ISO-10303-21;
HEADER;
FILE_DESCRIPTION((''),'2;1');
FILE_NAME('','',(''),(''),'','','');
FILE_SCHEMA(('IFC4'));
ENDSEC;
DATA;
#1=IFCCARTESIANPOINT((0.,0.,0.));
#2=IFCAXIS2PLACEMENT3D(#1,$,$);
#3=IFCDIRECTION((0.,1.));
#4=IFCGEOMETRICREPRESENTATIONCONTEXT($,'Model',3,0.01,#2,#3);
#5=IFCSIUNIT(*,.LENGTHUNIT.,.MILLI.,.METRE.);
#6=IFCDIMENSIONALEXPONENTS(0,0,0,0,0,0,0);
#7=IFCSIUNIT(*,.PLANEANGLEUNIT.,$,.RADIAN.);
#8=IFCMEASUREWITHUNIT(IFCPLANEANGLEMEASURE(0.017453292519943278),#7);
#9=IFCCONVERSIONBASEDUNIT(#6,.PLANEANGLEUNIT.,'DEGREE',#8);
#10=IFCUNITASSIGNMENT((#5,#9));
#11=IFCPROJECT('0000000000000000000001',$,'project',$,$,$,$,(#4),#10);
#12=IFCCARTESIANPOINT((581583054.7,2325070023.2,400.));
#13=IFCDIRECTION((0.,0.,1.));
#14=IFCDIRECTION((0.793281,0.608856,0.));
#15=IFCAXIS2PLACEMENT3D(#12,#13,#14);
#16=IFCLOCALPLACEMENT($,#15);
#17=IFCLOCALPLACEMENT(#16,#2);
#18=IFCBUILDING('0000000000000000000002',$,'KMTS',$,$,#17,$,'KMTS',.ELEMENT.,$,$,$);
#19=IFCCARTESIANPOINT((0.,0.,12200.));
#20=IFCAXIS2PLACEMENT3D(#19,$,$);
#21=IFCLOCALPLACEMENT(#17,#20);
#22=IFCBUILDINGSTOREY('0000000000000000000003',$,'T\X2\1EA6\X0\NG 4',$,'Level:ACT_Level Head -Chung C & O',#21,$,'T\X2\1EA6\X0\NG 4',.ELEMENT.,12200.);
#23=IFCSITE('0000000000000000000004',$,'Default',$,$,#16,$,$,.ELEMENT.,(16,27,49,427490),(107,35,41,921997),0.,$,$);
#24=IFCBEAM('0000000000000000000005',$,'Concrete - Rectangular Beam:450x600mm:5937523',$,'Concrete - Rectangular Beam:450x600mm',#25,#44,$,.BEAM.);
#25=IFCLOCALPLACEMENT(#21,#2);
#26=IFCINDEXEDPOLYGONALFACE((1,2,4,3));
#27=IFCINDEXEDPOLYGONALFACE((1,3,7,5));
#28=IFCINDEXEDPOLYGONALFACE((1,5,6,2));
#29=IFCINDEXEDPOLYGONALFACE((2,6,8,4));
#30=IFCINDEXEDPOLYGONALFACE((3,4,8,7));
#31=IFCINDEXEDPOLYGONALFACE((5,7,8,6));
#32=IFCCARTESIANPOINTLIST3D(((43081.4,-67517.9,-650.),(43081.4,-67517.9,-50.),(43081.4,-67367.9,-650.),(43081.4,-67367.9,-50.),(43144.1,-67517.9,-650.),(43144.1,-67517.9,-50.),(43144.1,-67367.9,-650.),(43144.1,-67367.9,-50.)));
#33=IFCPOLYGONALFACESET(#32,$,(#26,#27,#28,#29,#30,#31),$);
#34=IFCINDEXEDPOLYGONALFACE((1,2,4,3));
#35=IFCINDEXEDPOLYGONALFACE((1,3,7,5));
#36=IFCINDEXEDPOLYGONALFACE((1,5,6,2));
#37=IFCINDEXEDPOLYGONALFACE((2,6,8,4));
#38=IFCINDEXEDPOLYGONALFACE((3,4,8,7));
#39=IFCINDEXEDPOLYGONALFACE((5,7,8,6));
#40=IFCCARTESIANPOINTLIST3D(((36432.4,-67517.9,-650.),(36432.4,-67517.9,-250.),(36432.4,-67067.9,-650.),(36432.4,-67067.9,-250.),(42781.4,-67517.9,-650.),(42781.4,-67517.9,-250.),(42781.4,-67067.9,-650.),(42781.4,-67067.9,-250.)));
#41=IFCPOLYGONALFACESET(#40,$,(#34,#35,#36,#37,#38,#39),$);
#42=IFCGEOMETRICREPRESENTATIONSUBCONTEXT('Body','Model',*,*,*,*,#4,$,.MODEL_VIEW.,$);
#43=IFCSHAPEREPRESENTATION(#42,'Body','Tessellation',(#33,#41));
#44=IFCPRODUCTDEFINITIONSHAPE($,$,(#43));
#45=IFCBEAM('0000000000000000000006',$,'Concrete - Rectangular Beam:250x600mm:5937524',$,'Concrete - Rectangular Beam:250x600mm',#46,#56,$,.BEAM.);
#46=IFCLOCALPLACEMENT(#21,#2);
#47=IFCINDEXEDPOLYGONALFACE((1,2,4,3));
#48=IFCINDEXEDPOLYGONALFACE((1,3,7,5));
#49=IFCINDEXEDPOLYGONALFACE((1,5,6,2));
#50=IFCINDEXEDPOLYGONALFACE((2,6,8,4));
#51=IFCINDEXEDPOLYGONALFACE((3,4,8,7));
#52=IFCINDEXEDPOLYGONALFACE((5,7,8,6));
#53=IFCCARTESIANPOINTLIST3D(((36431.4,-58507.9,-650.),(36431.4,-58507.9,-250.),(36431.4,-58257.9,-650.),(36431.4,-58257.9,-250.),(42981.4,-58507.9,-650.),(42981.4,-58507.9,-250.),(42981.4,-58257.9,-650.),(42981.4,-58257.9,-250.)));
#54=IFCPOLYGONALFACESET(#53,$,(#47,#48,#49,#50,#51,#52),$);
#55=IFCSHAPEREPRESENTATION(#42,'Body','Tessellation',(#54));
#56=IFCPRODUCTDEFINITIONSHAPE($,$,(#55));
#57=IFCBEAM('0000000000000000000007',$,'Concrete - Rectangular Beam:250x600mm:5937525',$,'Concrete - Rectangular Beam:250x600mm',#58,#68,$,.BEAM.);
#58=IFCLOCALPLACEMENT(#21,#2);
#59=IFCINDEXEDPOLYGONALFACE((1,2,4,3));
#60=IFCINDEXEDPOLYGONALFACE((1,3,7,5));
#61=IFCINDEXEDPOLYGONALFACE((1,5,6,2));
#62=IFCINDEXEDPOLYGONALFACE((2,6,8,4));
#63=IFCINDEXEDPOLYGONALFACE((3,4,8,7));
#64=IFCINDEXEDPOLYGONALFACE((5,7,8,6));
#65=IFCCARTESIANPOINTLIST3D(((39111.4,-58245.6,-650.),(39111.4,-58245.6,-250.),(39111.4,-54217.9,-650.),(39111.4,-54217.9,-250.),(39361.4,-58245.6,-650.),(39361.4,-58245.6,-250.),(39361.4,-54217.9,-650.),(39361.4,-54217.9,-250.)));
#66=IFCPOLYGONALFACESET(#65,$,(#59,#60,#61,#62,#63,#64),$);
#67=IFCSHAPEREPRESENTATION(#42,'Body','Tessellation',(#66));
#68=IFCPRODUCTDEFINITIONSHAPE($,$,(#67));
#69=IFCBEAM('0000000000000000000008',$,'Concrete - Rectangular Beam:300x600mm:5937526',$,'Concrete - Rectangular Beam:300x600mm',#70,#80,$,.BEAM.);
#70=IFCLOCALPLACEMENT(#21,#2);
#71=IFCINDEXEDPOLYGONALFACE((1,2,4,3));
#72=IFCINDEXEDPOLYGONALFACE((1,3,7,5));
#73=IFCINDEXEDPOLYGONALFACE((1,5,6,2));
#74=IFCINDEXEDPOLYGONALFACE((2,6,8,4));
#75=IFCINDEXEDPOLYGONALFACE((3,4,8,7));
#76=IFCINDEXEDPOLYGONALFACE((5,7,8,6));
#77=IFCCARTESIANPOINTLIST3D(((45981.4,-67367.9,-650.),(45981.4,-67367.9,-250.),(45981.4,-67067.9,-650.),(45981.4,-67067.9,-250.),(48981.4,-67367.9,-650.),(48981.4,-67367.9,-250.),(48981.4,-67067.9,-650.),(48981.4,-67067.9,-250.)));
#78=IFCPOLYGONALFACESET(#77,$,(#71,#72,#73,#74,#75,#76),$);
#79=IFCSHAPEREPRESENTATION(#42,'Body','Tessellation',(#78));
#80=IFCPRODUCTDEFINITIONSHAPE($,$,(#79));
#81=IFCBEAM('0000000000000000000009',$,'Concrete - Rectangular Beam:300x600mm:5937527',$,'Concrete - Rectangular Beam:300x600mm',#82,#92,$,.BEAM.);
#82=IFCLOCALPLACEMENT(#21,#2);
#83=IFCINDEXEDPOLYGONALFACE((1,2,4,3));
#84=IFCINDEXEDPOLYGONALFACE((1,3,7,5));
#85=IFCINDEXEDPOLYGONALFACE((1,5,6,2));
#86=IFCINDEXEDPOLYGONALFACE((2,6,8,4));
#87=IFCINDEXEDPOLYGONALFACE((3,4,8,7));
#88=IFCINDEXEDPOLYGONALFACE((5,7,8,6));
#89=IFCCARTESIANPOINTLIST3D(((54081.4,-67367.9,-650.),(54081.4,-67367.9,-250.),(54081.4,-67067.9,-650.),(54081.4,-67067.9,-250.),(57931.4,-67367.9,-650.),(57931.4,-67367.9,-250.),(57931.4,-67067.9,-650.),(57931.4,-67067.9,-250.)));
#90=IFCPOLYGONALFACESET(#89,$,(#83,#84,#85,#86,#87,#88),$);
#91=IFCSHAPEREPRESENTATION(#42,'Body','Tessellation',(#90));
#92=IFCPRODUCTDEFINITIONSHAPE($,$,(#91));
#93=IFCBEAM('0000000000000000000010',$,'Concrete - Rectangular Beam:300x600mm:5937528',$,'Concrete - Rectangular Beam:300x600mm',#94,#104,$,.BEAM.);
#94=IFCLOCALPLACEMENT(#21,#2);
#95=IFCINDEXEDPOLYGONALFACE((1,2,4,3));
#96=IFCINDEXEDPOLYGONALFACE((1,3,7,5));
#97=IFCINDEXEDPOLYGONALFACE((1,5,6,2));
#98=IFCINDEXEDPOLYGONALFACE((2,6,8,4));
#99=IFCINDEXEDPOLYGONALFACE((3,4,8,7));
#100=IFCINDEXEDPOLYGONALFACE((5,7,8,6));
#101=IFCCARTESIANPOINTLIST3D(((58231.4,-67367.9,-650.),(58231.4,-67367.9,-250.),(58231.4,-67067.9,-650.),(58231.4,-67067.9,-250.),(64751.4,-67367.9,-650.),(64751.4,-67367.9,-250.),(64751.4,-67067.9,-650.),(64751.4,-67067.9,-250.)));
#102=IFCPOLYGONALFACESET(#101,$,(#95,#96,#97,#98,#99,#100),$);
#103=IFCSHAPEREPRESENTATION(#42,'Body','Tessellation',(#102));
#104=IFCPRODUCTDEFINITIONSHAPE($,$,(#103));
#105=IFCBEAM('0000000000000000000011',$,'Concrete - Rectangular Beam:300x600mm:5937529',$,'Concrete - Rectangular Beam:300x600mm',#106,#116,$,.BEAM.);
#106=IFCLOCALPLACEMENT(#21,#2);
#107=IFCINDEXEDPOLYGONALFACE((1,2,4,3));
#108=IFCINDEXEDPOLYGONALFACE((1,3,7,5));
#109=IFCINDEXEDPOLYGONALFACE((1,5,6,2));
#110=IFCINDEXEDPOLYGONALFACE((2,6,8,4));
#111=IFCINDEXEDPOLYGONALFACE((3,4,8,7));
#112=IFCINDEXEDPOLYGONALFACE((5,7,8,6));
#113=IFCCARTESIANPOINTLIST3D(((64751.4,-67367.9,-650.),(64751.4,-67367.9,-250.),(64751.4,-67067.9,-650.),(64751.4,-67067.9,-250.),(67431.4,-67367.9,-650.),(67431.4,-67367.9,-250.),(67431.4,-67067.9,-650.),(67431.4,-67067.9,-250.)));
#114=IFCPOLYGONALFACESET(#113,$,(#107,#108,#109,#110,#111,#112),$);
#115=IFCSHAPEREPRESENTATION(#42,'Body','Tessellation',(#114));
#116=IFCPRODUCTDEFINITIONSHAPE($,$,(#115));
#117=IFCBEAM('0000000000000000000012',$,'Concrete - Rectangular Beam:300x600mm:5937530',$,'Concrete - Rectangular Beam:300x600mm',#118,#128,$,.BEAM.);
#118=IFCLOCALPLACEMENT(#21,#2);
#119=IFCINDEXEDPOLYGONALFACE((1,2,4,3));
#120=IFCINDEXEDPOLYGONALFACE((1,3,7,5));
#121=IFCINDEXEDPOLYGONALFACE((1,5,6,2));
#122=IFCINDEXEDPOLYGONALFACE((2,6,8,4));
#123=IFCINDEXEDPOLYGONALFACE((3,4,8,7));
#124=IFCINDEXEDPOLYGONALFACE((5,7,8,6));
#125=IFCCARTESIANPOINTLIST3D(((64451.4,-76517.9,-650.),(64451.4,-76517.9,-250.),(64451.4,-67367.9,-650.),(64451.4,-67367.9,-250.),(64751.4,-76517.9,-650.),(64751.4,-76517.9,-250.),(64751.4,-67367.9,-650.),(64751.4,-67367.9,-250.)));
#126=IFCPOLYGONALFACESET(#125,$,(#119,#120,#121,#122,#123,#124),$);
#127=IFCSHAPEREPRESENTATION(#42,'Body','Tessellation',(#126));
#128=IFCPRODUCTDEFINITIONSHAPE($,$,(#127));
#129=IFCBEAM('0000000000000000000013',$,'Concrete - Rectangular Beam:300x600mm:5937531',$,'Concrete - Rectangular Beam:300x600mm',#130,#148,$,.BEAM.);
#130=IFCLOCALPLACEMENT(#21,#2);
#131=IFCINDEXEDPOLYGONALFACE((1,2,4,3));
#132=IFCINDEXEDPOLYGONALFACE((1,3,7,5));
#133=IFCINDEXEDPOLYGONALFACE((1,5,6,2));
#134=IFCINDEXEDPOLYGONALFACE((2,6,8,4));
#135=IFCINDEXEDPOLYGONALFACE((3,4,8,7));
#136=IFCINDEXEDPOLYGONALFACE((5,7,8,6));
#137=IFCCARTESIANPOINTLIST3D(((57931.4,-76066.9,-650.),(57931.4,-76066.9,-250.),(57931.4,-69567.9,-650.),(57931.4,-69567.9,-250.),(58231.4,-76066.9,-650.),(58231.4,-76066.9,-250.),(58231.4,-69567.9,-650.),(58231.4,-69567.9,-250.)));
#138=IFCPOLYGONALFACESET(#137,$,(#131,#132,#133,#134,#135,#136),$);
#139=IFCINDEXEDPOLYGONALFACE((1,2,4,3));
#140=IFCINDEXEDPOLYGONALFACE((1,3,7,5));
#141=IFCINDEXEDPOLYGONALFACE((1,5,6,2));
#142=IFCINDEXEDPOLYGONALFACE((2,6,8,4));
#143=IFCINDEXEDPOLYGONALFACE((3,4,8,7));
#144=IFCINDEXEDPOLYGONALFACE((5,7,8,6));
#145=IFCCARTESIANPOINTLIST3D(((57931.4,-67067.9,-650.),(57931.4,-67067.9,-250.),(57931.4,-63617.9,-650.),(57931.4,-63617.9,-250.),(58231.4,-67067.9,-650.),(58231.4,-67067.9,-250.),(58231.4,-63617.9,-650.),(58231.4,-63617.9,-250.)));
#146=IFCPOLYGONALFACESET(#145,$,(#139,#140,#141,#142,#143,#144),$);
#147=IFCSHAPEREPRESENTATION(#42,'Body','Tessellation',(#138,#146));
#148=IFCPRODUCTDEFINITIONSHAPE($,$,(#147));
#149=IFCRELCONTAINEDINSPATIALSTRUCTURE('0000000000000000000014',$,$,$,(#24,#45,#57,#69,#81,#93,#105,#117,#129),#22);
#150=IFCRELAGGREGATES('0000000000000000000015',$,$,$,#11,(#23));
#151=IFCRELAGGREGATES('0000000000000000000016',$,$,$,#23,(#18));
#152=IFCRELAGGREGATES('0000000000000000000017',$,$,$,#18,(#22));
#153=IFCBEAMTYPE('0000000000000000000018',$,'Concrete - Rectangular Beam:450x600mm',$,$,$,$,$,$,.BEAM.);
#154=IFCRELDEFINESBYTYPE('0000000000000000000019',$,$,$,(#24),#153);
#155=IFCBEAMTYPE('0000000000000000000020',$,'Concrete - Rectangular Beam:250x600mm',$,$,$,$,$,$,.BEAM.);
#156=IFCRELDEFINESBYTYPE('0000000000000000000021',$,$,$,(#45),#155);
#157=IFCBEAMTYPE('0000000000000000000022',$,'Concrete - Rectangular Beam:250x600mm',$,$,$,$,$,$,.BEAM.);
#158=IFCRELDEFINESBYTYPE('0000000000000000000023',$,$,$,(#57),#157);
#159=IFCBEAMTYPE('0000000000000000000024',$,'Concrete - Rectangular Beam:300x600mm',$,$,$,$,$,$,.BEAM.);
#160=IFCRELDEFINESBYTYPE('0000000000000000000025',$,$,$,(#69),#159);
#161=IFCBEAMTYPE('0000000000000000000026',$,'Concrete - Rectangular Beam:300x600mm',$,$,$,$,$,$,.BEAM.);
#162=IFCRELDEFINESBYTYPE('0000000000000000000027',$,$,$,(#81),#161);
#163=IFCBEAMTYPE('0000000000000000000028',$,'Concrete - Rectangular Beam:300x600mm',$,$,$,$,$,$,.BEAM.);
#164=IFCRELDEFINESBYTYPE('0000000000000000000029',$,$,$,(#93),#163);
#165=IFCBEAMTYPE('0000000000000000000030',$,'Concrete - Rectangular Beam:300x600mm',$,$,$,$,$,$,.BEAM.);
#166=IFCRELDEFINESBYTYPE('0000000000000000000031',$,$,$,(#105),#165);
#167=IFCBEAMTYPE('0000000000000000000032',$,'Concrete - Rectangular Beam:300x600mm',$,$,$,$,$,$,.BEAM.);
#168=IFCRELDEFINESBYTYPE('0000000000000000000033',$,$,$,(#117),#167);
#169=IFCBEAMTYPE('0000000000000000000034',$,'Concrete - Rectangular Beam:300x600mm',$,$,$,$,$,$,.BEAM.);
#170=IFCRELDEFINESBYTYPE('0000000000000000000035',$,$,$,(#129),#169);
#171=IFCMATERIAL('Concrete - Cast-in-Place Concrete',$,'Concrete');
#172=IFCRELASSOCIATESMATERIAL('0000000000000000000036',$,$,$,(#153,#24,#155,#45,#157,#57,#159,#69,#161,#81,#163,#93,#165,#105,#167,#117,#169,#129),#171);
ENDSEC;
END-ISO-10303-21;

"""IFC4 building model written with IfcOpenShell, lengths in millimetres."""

from ifc_helpers import new_model, entity, si_unit, converted_unit, direction, frame, origin, place, context, subcontext, project, spatial, indexed_curve, outline, extrude, source, transform, mapped, material, type_object, type_shapes, element, save


model = new_model("IFC4")

# Units and contexts
model_context = context("Model", 3, precision=0.01, world=origin(), true_north=direction((0.0, 1.0)))
body_context = subcontext(model_context, "Body", "Model", "MODEL_VIEW")
ifc_project = project(units=[si_unit("LENGTHUNIT", "METRE", prefix="MILLI"), converted_unit("PLANEANGLEUNIT", "DEGREE", entity("IfcPlaneAngleMeasure", 0.017453292519943278), si_unit("PLANEANGLEUNIT", "RADIAN"), dimensions=[0, 0, 0, 0, 0, 0, 0])], contexts=[model_context])

# Site, building, storey
site_placement = place(None, frame((581583054.7, 2325070023.2, 400.0), z_axis=(0.0, 0.0, 1.0), x_axis=(0.793281, 0.608856, 0.0)))
site = spatial("IfcSite", under=ifc_project, at=site_placement, Name="Default", CompositionType="ELEMENT", RefLatitude=(16, 27, 49, 427490), RefLongitude=(107, 35, 41, 921997), RefElevation=0.0)
building_placement = place(site_placement, origin())
building = spatial("IfcBuilding", under=site, at=building_placement, Name="KMTS", LongName="KMTS", CompositionType="ELEMENT")
storey_placement = place(building_placement, frame((0.0, 0.0, 12200.0)))
storey = spatial("IfcBuildingStorey", under=building, at=storey_placement, Name="TẦNG 4", ObjectType="Level:ACT_Level Head -Chung C & O", LongName="TẦNG 4", CompositionType="ELEMENT", Elevation=12200.0)

# Beams
ifc_material_1 = material(Name="Concrete - Cast-in-Place Concrete", Category="Concrete")
beam_type_1 = type_object("IfcBeamType", Name="Concrete - Rectangular Beam:450x600mm", PredefinedType="BEAM", material=ifc_material_1)
shared_shape_1 = source(origin(), body_context, "Body", "SweptSolid", [
    extrude(outline(indexed_curve([(-300.0, -75.0), (300.0, -75.0), (300.0, 75.0), (-300.0, 75.0), (-300.0, -75.0)], self_intersect=False)), frame((43081.4, -67442.9, 11850.0), z_axis=(1.0, 0.0, 0.0), x_axis=(0.0, 0.0, -1.0)), (0.0, 0.0, 1.0), 62.7),
    extrude(outline(indexed_curve([(-200.0, -225.0), (200.0, -225.0), (200.0, 225.0), (-200.0, 225.0), (-200.0, -225.0)], self_intersect=False)), frame((36432.4, -67292.9, 11750.0), z_axis=(1.0, 0.0, 0.0), x_axis=(0.0, 0.0, -1.0)), (0.0, 0.0, 1.0), 6349.0),
])
type_shapes(beam_type_1, [shared_shape_1])
beam_1_placement = place(storey_placement, frame((0.0, 0.0, -12200.0)))
element("IfcBeam", 1, at=beam_1_placement, inside=storey, type_object=beam_type_1, material=ifc_material_1, Name="Concrete - Rectangular Beam:450x600mm:5937523", ObjectType="Concrete - Rectangular Beam:450x600mm", PredefinedType="BEAM", context=body_context, shape_type="MappedRepresentation", body=[
    mapped(shared_shape_1, transform((0.0, 0.0, 0.0), scale=1.0)),
])
beam_type_2 = type_object("IfcBeamType", Name="Concrete - Rectangular Beam:250x600mm", PredefinedType="BEAM", material=ifc_material_1)
shared_shape_2 = source(origin(), body_context, "Body", "SweptSolid", [
    extrude(outline(indexed_curve([(-200.0, -125.0), (200.0, -125.0), (200.0, 125.0), (-200.0, 125.0), (-200.0, -125.0)], self_intersect=False)), frame((42981.4, -58382.9, 11750.0), z_axis=(-1.0, 0.0, 0.0), x_axis=(0.0, 0.0, -1.0)), (0.0, 0.0, 1.0), 6550.0),
])
type_shapes(beam_type_2, [shared_shape_2])
beam_2_placement = place(storey_placement, frame((0.0, 0.0, -12200.0)))
element("IfcBeam", 2, at=beam_2_placement, inside=storey, type_object=beam_type_2, material=ifc_material_1, Name="Concrete - Rectangular Beam:250x600mm:5937524", ObjectType="Concrete - Rectangular Beam:250x600mm", PredefinedType="BEAM", context=body_context, shape_type="MappedRepresentation", body=[
    mapped(shared_shape_2, transform((0.0, 0.0, 0.0), scale=1.0)),
])
beam_type_3 = type_object("IfcBeamType", Name="Concrete - Rectangular Beam:250x600mm", PredefinedType="BEAM", material=ifc_material_1)
shared_shape_3 = source(origin(), body_context, "Body", "SweptSolid", [
    extrude(outline(indexed_curve([(-125.0, -200.0), (125.0, -200.0), (125.0, 200.0), (-125.0, 200.0), (-125.0, -200.0)], self_intersect=False)), frame((39236.4, -54217.9, 11750.0), z_axis=(0.0, -1.0, 0.0), x_axis=(-1.0, 0.0, 0.0)), (0.0, 0.0, 1.0), 4027.7),
])
type_shapes(beam_type_3, [shared_shape_3])
beam_3_placement = place(storey_placement, frame((0.0, 0.0, -12200.0)))
element("IfcBeam", 3, at=beam_3_placement, inside=storey, type_object=beam_type_3, material=ifc_material_1, Name="Concrete - Rectangular Beam:250x600mm:5937525", ObjectType="Concrete - Rectangular Beam:250x600mm", PredefinedType="BEAM", context=body_context, shape_type="MappedRepresentation", body=[
    mapped(shared_shape_3, transform((0.0, 0.0, 0.0), scale=1.0)),
])
beam_type_4 = type_object("IfcBeamType", Name="Concrete - Rectangular Beam:300x600mm", PredefinedType="BEAM", material=ifc_material_1)
shared_shape_4 = source(origin(), body_context, "Body", "SweptSolid", [
    extrude(outline(indexed_curve([(-200.0, -150.0), (200.0, -150.0), (200.0, 150.0), (-200.0, 150.0), (-200.0, -150.0)], self_intersect=False)), frame((48981.4, -67217.9, 11750.0), z_axis=(-1.0, 0.0, 0.0), x_axis=(0.0, 0.0, -1.0)), (0.0, 0.0, 1.0), 3000.0),
])
type_shapes(beam_type_4, [shared_shape_4])
beam_4_placement = place(storey_placement, frame((0.0, 0.0, -12200.0)))
element("IfcBeam", 4, at=beam_4_placement, inside=storey, type_object=beam_type_4, material=ifc_material_1, Name="Concrete - Rectangular Beam:300x600mm:5937526", ObjectType="Concrete - Rectangular Beam:300x600mm", PredefinedType="BEAM", context=body_context, shape_type="MappedRepresentation", body=[
    mapped(shared_shape_4, transform((0.0, 0.0, 0.0), scale=1.0)),
])
beam_type_5 = type_object("IfcBeamType", Name="Concrete - Rectangular Beam:300x600mm", PredefinedType="BEAM", material=ifc_material_1)
shared_shape_5 = source(origin(), body_context, "Body", "SweptSolid", [
    extrude(outline(indexed_curve([(-200.0, -150.0), (200.0, -150.0), (200.0, 150.0), (-200.0, 150.0), (-200.0, -150.0)], self_intersect=False)), frame((54081.4, -67217.9, 11750.0), z_axis=(1.0, 0.0, 0.0), x_axis=(0.0, 0.0, -1.0)), (0.0, 0.0, 1.0), 3850.0),
])
type_shapes(beam_type_5, [shared_shape_5])
beam_5_placement = place(storey_placement, frame((0.0, 0.0, -12200.0)))
element("IfcBeam", 5, at=beam_5_placement, inside=storey, type_object=beam_type_5, material=ifc_material_1, Name="Concrete - Rectangular Beam:300x600mm:5937527", ObjectType="Concrete - Rectangular Beam:300x600mm", PredefinedType="BEAM", context=body_context, shape_type="MappedRepresentation", body=[
    mapped(shared_shape_5, transform((0.0, 0.0, 0.0), scale=1.0)),
])
beam_type_6 = type_object("IfcBeamType", Name="Concrete - Rectangular Beam:300x600mm", PredefinedType="BEAM", material=ifc_material_1)
shared_shape_6 = source(origin(), body_context, "Body", "SweptSolid", [
    extrude(outline(indexed_curve([(-200.0, -150.0), (200.0, -150.0), (200.0, 150.0), (-200.0, 150.0), (-200.0, -150.0)], self_intersect=False)), frame((58231.4, -67217.9, 11750.0), z_axis=(1.0, 0.0, 0.0), x_axis=(0.0, 0.0, -1.0)), (0.0, 0.0, 1.0), 6520.0),
])
type_shapes(beam_type_6, [shared_shape_6])
beam_6_placement = place(storey_placement, frame((0.0, 0.0, -12200.0)))
element("IfcBeam", 6, at=beam_6_placement, inside=storey, type_object=beam_type_6, material=ifc_material_1, Name="Concrete - Rectangular Beam:300x600mm:5937528", ObjectType="Concrete - Rectangular Beam:300x600mm", PredefinedType="BEAM", context=body_context, shape_type="MappedRepresentation", body=[
    mapped(shared_shape_6, transform((0.0, 0.0, 0.0), scale=1.0)),
])
beam_type_7 = type_object("IfcBeamType", Name="Concrete - Rectangular Beam:300x600mm", PredefinedType="BEAM", material=ifc_material_1)
shared_shape_7 = source(origin(), body_context, "Body", "SweptSolid", [
    extrude(outline(indexed_curve([(-200.0, -150.0), (200.0, -150.0), (200.0, 150.0), (-200.0, 150.0), (-200.0, -150.0)], self_intersect=False)), frame((67431.4, -67217.9, 11750.0), z_axis=(-1.0, 0.0, 0.0), x_axis=(0.0, 0.0, -1.0)), (0.0, 0.0, 1.0), 2680.0),
])
type_shapes(beam_type_7, [shared_shape_7])
beam_7_placement = place(storey_placement, frame((0.0, 0.0, -12200.0)))
element("IfcBeam", 7, at=beam_7_placement, inside=storey, type_object=beam_type_7, material=ifc_material_1, Name="Concrete - Rectangular Beam:300x600mm:5937529", ObjectType="Concrete - Rectangular Beam:300x600mm", PredefinedType="BEAM", context=body_context, shape_type="MappedRepresentation", body=[
    mapped(shared_shape_7, transform((0.0, 0.0, 0.0), scale=1.0)),
])
beam_type_8 = type_object("IfcBeamType", Name="Concrete - Rectangular Beam:300x600mm", PredefinedType="BEAM", material=ifc_material_1)
shared_shape_8 = source(origin(), body_context, "Body", "SweptSolid", [
    extrude(outline(indexed_curve([(-150.0, -200.0), (150.0, -200.0), (150.0, 200.0), (-150.0, 200.0), (-150.0, -200.0)], self_intersect=False)), frame((64601.4, -67367.9, 11750.0), z_axis=(0.0, -1.0, 0.0), x_axis=(-1.0, 0.0, 0.0)), (0.0, 0.0, 1.0), 9150.0),
])
type_shapes(beam_type_8, [shared_shape_8])
beam_8_placement = place(storey_placement, frame((0.0, 0.0, -12200.0)))
element("IfcBeam", 8, at=beam_8_placement, inside=storey, type_object=beam_type_8, material=ifc_material_1, Name="Concrete - Rectangular Beam:300x600mm:5937530", ObjectType="Concrete - Rectangular Beam:300x600mm", PredefinedType="BEAM", context=body_context, shape_type="MappedRepresentation", body=[
    mapped(shared_shape_8, transform((0.0, 0.0, 0.0), scale=1.0)),
])
beam_type_9 = type_object("IfcBeamType", Name="Concrete - Rectangular Beam:300x600mm", PredefinedType="BEAM", material=ifc_material_1)
shared_shape_9 = source(origin(), body_context, "Body", "SweptSolid", [
    extrude(outline(indexed_curve([(-150.0, -200.0), (150.0, -200.0), (150.0, 200.0), (-150.0, 200.0), (-150.0, -200.0)], self_intersect=False)), frame((58081.4, -69567.9, 11750.0), z_axis=(0.0, -1.0, 0.0), x_axis=(-1.0, 0.0, 0.0)), (0.0, 0.0, 1.0), 6499.0),
    extrude(outline(indexed_curve([(-150.0, -200.0), (150.0, -200.0), (150.0, 200.0), (-150.0, 200.0), (-150.0, -200.0)], self_intersect=False)), frame((58081.4, -63617.9, 11750.0), z_axis=(0.0, -1.0, 0.0), x_axis=(-1.0, 0.0, 0.0)), (0.0, 0.0, 1.0), 3450.0),
])
type_shapes(beam_type_9, [shared_shape_9])
beam_9_placement = place(storey_placement, frame((0.0, 0.0, -12200.0)))
element("IfcBeam", 9, at=beam_9_placement, inside=storey, type_object=beam_type_9, material=ifc_material_1, Name="Concrete - Rectangular Beam:300x600mm:5937531", ObjectType="Concrete - Rectangular Beam:300x600mm", PredefinedType="BEAM", context=body_context, shape_type="MappedRepresentation", body=[
    mapped(shared_shape_9, transform((0.0, 0.0, 0.0), scale=1.0)),
])

save(model, "model.ifc")
